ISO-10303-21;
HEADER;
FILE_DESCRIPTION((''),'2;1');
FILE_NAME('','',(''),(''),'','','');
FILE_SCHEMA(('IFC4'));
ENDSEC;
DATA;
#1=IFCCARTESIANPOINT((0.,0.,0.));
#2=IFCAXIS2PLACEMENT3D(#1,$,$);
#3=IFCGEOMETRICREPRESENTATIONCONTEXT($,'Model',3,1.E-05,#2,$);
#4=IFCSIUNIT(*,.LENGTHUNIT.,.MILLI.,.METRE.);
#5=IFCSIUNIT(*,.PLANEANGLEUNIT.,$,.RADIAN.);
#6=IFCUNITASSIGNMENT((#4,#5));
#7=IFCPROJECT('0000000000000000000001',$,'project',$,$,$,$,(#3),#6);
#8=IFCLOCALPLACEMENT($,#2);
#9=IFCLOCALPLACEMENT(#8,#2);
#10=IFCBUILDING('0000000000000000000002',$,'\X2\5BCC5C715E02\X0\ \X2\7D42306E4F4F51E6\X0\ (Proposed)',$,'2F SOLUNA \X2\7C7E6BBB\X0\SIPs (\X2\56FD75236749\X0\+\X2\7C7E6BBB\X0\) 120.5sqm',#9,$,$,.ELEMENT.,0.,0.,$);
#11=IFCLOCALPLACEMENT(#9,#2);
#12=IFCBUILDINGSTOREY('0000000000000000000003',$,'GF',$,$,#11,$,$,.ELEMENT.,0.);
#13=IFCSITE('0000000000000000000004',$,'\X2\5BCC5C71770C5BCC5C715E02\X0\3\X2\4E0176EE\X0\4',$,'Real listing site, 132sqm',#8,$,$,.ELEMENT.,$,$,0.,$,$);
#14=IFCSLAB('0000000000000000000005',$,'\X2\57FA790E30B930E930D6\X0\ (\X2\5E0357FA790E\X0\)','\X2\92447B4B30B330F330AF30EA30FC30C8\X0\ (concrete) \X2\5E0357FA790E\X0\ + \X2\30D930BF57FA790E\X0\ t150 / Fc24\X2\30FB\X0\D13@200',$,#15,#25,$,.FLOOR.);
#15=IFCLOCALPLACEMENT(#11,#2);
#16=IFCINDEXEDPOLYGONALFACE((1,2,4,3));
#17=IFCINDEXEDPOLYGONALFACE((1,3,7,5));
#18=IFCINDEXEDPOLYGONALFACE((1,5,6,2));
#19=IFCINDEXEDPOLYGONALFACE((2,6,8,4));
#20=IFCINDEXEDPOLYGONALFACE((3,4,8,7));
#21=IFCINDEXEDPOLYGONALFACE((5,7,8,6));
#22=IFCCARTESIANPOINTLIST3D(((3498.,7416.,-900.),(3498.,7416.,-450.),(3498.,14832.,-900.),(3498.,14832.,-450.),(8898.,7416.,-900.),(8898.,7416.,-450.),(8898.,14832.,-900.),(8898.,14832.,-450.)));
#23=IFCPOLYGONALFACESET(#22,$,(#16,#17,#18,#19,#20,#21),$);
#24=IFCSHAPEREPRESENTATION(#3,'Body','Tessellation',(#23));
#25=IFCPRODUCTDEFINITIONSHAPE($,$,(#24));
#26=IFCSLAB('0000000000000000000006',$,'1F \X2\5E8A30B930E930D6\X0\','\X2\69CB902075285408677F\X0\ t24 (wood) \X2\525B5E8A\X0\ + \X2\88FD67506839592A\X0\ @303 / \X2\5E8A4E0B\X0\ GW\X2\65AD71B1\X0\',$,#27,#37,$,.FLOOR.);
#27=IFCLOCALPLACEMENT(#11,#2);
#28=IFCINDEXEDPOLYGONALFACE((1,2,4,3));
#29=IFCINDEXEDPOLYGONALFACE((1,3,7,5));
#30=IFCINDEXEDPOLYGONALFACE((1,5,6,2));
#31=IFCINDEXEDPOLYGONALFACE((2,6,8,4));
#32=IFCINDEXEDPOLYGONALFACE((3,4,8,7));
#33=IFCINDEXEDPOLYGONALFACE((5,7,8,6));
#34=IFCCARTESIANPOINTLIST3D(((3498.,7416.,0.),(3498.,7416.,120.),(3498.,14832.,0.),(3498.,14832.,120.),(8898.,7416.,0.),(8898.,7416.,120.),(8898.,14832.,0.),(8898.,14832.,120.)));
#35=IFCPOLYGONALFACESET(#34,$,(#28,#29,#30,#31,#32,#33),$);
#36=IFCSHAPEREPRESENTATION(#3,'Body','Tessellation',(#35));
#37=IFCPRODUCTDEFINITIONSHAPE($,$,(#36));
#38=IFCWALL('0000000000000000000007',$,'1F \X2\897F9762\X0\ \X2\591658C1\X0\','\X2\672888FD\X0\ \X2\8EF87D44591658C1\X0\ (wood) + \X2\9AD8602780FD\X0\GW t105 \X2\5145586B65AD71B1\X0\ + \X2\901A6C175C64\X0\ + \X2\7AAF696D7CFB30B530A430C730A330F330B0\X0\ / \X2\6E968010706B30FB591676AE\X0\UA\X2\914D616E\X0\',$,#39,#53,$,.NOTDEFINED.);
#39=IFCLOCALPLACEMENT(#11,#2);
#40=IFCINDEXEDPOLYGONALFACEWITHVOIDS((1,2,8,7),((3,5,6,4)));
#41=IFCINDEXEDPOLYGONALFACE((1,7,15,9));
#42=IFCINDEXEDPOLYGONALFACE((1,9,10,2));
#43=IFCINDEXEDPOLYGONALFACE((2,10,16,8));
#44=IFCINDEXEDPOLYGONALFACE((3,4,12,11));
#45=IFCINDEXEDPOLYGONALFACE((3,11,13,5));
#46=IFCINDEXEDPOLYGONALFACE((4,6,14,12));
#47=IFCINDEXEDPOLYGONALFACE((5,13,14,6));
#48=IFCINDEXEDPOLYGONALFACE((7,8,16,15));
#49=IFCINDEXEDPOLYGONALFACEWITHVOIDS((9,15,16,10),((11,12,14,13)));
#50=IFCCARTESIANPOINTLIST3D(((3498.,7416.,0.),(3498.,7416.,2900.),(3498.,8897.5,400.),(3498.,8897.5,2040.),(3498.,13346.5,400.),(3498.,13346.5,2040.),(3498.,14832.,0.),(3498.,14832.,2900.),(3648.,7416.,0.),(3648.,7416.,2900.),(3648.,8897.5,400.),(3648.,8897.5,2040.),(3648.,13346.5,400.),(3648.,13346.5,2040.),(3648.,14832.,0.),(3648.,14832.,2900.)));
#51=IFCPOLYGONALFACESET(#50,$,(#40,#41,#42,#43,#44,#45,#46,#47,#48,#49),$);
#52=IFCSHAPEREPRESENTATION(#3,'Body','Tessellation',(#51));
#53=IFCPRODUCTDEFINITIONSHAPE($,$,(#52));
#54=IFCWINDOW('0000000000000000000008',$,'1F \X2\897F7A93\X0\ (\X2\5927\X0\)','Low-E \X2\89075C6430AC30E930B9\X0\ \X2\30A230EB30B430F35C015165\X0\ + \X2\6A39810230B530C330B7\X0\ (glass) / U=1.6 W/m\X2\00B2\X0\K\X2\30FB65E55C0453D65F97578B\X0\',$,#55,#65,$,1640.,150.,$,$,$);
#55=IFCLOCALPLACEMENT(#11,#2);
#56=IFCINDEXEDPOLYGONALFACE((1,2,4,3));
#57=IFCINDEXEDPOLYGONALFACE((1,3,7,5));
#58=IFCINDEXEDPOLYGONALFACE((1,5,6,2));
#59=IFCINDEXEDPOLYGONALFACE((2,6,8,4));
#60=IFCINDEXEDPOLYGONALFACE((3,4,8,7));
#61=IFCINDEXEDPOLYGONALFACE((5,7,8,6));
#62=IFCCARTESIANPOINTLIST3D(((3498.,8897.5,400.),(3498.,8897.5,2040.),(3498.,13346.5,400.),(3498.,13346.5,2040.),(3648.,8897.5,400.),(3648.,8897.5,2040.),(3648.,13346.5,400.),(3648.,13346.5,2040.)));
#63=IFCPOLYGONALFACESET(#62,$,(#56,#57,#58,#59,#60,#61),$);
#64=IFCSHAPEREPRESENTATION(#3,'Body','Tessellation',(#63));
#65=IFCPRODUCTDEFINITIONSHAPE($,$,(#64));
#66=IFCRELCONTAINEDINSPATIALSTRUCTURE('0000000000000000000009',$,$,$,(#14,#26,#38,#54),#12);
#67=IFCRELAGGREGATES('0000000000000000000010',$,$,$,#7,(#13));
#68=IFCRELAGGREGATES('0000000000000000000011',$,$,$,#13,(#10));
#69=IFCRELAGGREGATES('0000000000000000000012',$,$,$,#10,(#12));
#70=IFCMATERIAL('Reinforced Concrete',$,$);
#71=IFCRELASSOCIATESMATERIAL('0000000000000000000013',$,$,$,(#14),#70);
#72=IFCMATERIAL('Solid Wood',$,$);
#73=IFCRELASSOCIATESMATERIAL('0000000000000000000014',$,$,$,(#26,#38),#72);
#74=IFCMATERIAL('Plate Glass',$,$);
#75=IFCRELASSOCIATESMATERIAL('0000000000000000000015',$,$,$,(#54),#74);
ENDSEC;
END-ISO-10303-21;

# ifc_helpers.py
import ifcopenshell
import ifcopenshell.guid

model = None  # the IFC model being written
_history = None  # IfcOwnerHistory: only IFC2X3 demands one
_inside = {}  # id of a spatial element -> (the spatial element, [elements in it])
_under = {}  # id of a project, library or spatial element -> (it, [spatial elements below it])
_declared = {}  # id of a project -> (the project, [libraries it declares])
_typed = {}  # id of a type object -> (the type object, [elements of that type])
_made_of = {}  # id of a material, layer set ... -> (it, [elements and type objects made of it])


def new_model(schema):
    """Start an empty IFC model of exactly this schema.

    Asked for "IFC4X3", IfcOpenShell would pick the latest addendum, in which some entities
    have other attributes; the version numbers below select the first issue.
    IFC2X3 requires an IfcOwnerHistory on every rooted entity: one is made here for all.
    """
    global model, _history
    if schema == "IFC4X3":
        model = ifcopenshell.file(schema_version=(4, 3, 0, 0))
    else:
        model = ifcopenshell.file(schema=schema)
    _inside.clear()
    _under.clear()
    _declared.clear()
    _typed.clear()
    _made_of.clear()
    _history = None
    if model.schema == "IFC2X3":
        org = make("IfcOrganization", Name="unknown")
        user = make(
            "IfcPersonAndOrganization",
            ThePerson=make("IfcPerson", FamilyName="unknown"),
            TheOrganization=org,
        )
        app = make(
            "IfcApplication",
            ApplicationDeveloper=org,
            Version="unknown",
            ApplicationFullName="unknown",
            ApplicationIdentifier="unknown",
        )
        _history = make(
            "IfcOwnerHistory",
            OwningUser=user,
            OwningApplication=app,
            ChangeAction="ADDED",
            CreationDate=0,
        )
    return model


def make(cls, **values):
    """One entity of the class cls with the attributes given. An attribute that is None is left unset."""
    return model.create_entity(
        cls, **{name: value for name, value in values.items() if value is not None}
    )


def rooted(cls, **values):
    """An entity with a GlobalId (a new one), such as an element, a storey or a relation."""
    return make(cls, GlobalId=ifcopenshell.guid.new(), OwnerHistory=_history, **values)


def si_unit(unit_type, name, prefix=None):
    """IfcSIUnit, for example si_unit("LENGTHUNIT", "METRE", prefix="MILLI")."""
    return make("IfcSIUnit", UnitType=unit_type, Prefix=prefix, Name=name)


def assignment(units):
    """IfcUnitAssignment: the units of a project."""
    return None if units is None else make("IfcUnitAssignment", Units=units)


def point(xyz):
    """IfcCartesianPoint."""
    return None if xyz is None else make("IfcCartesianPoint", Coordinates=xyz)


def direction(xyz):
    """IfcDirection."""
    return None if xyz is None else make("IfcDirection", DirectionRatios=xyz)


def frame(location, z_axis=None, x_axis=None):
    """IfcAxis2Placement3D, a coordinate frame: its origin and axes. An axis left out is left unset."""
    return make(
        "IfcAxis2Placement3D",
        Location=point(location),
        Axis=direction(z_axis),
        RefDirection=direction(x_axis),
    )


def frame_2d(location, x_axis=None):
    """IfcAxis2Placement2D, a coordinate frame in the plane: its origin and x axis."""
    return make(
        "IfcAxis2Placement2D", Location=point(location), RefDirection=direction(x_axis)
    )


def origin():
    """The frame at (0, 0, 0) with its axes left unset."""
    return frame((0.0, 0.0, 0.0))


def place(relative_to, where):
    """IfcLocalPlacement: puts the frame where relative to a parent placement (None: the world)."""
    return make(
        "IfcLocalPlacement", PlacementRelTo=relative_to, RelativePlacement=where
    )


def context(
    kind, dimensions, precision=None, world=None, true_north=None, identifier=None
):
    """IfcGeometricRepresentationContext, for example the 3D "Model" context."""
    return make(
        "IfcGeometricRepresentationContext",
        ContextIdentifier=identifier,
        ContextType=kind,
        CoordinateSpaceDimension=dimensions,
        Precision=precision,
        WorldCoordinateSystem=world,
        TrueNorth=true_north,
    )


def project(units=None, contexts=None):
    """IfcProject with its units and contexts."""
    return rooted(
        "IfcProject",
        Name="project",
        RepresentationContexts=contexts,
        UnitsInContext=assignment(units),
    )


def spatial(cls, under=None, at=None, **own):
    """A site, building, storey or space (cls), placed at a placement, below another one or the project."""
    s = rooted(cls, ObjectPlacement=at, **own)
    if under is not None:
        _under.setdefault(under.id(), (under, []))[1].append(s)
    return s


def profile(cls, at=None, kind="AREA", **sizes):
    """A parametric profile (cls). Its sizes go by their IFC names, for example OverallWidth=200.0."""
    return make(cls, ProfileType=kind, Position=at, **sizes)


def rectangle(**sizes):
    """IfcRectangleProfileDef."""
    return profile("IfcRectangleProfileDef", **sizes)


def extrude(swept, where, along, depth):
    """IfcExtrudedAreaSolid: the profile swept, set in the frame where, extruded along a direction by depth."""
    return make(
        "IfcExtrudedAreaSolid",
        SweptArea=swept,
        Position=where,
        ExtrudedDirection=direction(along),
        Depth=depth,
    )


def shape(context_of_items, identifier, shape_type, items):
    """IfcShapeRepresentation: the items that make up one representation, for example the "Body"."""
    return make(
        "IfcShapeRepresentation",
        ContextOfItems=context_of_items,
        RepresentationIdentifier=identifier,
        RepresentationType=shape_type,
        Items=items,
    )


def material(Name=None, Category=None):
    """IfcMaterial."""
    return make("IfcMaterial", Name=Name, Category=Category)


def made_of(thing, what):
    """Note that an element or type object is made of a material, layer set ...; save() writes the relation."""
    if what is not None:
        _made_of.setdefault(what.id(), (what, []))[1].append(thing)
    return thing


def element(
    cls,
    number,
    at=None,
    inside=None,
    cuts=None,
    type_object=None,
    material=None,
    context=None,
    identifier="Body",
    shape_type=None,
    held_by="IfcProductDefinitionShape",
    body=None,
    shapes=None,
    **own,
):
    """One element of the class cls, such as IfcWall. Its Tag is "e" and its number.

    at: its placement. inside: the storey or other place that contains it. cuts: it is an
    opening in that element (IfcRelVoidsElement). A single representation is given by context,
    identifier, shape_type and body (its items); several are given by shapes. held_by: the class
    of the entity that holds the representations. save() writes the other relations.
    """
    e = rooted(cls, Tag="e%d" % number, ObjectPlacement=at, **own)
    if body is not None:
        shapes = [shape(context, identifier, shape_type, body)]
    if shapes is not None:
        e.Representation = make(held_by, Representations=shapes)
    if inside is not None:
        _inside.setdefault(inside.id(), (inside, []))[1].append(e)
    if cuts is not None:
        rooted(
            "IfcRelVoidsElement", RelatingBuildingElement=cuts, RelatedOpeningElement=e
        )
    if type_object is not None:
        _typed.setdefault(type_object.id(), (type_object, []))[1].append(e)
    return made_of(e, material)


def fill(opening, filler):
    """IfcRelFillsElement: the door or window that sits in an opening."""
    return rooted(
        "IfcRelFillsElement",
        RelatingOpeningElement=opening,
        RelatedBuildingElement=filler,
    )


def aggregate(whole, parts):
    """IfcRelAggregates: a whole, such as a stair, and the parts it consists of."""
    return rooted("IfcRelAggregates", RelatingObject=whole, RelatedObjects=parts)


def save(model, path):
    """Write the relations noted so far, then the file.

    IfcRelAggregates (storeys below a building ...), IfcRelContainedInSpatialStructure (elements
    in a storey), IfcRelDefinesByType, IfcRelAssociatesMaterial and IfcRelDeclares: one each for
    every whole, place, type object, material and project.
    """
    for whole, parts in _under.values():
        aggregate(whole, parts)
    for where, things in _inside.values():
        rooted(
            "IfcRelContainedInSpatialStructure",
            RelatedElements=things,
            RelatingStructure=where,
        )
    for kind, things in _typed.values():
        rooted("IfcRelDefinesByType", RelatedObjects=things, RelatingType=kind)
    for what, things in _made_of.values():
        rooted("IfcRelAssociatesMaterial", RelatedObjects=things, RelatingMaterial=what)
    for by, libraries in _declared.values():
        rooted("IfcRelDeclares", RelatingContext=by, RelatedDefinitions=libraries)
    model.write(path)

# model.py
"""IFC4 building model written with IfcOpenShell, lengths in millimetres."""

from ifc_helpers import new_model, si_unit, frame, frame_2d, origin, place, context, project, spatial, rectangle, extrude, material, element, fill, save


model = new_model("IFC4")

# Units and contexts
model_context = context("Model", 3, precision=1e-05, world=origin())
ifc_project = project(units=[si_unit("LENGTHUNIT", "METRE", prefix="MILLI"), si_unit("PLANEANGLEUNIT", "RADIAN")], contexts=[model_context])

# Site, building, storey
site_placement = place(None, origin())
site = spatial("IfcSite", under=ifc_project, at=site_placement, Name="富山県富山市3丁目4", ObjectType="Real listing site, 132sqm", CompositionType="ELEMENT", RefElevation=0.0)
building_placement = place(site_placement, origin())
building = spatial("IfcBuilding", under=site, at=building_placement, Name="富山市 終の住処 (Proposed)", ObjectType="2F SOLUNA 籾殻SIPs (国産杉+籾殻) 120.5sqm", CompositionType="ELEMENT", ElevationOfRefHeight=0.0, ElevationOfTerrain=0.0)
storey_placement = place(building_placement, origin())
storey = spatial("IfcBuildingStorey", under=building, at=storey_placement, Name="GF", CompositionType="ELEMENT", Elevation=0.0)

# Slabs
ifc_material_1 = material(Name="Reinforced Concrete")
slab_1_placement = place(storey_placement, frame((1749.0, 3708.0, -450.0)))
element("IfcSlab", 1, at=slab_1_placement, inside=storey, material=ifc_material_1, Name="基礎スラブ (布基礎)", Description="鉄筋コンクリート (concrete) 布基礎 + ベタ基礎 t150 / Fc24・D13@200", PredefinedType="FLOOR", context=model_context, shape_type="SweptSolid", body=[
    extrude(rectangle(XDim=5400.0, YDim=7416.0, at=frame_2d((2700.0, 3708.0))), frame((1749.0, 3708.0, -450.0)), (0.0, 0.0, 1.0), 450.0),
])
ifc_material_2 = material(Name="Solid Wood")
slab_2_placement = place(storey_placement, frame((1749.0, 3708.0, 0.0)))
element("IfcSlab", 2, at=slab_2_placement, inside=storey, material=ifc_material_2, Name="1F 床スラブ", Description="構造用合板 t24 (wood) 剛床 + 製材根太 @303 / 床下 GW断熱", PredefinedType="FLOOR", context=model_context, shape_type="SweptSolid", body=[
    extrude(rectangle(XDim=5400.0, YDim=7416.0, at=frame_2d((2700.0, 3708.0))), frame((1749.0, 3708.0, 0.0)), (0.0, 0.0, 1.0), 120.0),
])

# Shared definitions
ifc_material_3 = material(Name="Plate Glass")

# Wall, opening, window
wall_1_placement = place(storey_placement, frame((1749.0, 3708.0, 0.0)))
wall_1 = element("IfcWall", 3, at=wall_1_placement, inside=storey, material=ifc_material_2, Name="1F 西面 外壁", Description="木製 軸組外壁 (wood) + 高性能GW t105 充填断熱 + 通気層 + 窯業系サイディング / 準耐火・外皮UA配慮", PredefinedType="NOTDEFINED", context=model_context, shape_type="SweptSolid", body=[
    extrude(rectangle(XDim=150.0, YDim=7416.0, at=frame_2d((75.0, 3708.0))), frame((1749.0, 3708.0, 0.0)), (0.0, 0.0, 1.0), 2900.0),
])
opening_1_placement = place(storey_placement, frame((1749.0, 4449.0, 200.0)))
opening_1 = element("IfcOpeningElement", 4, at=opening_1_placement, cuts=wall_1, PredefinedType="NOTDEFINED", context=model_context, shape_type="SweptSolid", body=[
    extrude(rectangle(XDim=150.0, YDim=4449.0, at=frame_2d((75.0, 2224.0))), frame((1749.0, 4449.0, 200.0)), (0.0, 0.0, 1.0), 1640.0),
])
window_1_placement = place(storey_placement, frame((1749.0, 4449.0, 200.0)))
window_1 = element("IfcWindow", 5, at=window_1_placement, inside=storey, material=ifc_material_3, Name="1F 西窓 (大)", Description="Low-E 複層ガラス アルゴン封入 + 樹脂サッシ (glass) / U=1.6 W/m²K・日射取得型", OverallHeight=1640.0, OverallWidth=150.0, context=model_context, shape_type="SweptSolid", body=[
    extrude(rectangle(XDim=150.0, YDim=4449.0, at=frame_2d((75.0, 2224.0))), frame((1749.0, 4449.0, 200.0)), (0.0, 0.0, 1.0), 1640.0),
])
fill(opening_1, window_1)

save(model, "model.ifc")
